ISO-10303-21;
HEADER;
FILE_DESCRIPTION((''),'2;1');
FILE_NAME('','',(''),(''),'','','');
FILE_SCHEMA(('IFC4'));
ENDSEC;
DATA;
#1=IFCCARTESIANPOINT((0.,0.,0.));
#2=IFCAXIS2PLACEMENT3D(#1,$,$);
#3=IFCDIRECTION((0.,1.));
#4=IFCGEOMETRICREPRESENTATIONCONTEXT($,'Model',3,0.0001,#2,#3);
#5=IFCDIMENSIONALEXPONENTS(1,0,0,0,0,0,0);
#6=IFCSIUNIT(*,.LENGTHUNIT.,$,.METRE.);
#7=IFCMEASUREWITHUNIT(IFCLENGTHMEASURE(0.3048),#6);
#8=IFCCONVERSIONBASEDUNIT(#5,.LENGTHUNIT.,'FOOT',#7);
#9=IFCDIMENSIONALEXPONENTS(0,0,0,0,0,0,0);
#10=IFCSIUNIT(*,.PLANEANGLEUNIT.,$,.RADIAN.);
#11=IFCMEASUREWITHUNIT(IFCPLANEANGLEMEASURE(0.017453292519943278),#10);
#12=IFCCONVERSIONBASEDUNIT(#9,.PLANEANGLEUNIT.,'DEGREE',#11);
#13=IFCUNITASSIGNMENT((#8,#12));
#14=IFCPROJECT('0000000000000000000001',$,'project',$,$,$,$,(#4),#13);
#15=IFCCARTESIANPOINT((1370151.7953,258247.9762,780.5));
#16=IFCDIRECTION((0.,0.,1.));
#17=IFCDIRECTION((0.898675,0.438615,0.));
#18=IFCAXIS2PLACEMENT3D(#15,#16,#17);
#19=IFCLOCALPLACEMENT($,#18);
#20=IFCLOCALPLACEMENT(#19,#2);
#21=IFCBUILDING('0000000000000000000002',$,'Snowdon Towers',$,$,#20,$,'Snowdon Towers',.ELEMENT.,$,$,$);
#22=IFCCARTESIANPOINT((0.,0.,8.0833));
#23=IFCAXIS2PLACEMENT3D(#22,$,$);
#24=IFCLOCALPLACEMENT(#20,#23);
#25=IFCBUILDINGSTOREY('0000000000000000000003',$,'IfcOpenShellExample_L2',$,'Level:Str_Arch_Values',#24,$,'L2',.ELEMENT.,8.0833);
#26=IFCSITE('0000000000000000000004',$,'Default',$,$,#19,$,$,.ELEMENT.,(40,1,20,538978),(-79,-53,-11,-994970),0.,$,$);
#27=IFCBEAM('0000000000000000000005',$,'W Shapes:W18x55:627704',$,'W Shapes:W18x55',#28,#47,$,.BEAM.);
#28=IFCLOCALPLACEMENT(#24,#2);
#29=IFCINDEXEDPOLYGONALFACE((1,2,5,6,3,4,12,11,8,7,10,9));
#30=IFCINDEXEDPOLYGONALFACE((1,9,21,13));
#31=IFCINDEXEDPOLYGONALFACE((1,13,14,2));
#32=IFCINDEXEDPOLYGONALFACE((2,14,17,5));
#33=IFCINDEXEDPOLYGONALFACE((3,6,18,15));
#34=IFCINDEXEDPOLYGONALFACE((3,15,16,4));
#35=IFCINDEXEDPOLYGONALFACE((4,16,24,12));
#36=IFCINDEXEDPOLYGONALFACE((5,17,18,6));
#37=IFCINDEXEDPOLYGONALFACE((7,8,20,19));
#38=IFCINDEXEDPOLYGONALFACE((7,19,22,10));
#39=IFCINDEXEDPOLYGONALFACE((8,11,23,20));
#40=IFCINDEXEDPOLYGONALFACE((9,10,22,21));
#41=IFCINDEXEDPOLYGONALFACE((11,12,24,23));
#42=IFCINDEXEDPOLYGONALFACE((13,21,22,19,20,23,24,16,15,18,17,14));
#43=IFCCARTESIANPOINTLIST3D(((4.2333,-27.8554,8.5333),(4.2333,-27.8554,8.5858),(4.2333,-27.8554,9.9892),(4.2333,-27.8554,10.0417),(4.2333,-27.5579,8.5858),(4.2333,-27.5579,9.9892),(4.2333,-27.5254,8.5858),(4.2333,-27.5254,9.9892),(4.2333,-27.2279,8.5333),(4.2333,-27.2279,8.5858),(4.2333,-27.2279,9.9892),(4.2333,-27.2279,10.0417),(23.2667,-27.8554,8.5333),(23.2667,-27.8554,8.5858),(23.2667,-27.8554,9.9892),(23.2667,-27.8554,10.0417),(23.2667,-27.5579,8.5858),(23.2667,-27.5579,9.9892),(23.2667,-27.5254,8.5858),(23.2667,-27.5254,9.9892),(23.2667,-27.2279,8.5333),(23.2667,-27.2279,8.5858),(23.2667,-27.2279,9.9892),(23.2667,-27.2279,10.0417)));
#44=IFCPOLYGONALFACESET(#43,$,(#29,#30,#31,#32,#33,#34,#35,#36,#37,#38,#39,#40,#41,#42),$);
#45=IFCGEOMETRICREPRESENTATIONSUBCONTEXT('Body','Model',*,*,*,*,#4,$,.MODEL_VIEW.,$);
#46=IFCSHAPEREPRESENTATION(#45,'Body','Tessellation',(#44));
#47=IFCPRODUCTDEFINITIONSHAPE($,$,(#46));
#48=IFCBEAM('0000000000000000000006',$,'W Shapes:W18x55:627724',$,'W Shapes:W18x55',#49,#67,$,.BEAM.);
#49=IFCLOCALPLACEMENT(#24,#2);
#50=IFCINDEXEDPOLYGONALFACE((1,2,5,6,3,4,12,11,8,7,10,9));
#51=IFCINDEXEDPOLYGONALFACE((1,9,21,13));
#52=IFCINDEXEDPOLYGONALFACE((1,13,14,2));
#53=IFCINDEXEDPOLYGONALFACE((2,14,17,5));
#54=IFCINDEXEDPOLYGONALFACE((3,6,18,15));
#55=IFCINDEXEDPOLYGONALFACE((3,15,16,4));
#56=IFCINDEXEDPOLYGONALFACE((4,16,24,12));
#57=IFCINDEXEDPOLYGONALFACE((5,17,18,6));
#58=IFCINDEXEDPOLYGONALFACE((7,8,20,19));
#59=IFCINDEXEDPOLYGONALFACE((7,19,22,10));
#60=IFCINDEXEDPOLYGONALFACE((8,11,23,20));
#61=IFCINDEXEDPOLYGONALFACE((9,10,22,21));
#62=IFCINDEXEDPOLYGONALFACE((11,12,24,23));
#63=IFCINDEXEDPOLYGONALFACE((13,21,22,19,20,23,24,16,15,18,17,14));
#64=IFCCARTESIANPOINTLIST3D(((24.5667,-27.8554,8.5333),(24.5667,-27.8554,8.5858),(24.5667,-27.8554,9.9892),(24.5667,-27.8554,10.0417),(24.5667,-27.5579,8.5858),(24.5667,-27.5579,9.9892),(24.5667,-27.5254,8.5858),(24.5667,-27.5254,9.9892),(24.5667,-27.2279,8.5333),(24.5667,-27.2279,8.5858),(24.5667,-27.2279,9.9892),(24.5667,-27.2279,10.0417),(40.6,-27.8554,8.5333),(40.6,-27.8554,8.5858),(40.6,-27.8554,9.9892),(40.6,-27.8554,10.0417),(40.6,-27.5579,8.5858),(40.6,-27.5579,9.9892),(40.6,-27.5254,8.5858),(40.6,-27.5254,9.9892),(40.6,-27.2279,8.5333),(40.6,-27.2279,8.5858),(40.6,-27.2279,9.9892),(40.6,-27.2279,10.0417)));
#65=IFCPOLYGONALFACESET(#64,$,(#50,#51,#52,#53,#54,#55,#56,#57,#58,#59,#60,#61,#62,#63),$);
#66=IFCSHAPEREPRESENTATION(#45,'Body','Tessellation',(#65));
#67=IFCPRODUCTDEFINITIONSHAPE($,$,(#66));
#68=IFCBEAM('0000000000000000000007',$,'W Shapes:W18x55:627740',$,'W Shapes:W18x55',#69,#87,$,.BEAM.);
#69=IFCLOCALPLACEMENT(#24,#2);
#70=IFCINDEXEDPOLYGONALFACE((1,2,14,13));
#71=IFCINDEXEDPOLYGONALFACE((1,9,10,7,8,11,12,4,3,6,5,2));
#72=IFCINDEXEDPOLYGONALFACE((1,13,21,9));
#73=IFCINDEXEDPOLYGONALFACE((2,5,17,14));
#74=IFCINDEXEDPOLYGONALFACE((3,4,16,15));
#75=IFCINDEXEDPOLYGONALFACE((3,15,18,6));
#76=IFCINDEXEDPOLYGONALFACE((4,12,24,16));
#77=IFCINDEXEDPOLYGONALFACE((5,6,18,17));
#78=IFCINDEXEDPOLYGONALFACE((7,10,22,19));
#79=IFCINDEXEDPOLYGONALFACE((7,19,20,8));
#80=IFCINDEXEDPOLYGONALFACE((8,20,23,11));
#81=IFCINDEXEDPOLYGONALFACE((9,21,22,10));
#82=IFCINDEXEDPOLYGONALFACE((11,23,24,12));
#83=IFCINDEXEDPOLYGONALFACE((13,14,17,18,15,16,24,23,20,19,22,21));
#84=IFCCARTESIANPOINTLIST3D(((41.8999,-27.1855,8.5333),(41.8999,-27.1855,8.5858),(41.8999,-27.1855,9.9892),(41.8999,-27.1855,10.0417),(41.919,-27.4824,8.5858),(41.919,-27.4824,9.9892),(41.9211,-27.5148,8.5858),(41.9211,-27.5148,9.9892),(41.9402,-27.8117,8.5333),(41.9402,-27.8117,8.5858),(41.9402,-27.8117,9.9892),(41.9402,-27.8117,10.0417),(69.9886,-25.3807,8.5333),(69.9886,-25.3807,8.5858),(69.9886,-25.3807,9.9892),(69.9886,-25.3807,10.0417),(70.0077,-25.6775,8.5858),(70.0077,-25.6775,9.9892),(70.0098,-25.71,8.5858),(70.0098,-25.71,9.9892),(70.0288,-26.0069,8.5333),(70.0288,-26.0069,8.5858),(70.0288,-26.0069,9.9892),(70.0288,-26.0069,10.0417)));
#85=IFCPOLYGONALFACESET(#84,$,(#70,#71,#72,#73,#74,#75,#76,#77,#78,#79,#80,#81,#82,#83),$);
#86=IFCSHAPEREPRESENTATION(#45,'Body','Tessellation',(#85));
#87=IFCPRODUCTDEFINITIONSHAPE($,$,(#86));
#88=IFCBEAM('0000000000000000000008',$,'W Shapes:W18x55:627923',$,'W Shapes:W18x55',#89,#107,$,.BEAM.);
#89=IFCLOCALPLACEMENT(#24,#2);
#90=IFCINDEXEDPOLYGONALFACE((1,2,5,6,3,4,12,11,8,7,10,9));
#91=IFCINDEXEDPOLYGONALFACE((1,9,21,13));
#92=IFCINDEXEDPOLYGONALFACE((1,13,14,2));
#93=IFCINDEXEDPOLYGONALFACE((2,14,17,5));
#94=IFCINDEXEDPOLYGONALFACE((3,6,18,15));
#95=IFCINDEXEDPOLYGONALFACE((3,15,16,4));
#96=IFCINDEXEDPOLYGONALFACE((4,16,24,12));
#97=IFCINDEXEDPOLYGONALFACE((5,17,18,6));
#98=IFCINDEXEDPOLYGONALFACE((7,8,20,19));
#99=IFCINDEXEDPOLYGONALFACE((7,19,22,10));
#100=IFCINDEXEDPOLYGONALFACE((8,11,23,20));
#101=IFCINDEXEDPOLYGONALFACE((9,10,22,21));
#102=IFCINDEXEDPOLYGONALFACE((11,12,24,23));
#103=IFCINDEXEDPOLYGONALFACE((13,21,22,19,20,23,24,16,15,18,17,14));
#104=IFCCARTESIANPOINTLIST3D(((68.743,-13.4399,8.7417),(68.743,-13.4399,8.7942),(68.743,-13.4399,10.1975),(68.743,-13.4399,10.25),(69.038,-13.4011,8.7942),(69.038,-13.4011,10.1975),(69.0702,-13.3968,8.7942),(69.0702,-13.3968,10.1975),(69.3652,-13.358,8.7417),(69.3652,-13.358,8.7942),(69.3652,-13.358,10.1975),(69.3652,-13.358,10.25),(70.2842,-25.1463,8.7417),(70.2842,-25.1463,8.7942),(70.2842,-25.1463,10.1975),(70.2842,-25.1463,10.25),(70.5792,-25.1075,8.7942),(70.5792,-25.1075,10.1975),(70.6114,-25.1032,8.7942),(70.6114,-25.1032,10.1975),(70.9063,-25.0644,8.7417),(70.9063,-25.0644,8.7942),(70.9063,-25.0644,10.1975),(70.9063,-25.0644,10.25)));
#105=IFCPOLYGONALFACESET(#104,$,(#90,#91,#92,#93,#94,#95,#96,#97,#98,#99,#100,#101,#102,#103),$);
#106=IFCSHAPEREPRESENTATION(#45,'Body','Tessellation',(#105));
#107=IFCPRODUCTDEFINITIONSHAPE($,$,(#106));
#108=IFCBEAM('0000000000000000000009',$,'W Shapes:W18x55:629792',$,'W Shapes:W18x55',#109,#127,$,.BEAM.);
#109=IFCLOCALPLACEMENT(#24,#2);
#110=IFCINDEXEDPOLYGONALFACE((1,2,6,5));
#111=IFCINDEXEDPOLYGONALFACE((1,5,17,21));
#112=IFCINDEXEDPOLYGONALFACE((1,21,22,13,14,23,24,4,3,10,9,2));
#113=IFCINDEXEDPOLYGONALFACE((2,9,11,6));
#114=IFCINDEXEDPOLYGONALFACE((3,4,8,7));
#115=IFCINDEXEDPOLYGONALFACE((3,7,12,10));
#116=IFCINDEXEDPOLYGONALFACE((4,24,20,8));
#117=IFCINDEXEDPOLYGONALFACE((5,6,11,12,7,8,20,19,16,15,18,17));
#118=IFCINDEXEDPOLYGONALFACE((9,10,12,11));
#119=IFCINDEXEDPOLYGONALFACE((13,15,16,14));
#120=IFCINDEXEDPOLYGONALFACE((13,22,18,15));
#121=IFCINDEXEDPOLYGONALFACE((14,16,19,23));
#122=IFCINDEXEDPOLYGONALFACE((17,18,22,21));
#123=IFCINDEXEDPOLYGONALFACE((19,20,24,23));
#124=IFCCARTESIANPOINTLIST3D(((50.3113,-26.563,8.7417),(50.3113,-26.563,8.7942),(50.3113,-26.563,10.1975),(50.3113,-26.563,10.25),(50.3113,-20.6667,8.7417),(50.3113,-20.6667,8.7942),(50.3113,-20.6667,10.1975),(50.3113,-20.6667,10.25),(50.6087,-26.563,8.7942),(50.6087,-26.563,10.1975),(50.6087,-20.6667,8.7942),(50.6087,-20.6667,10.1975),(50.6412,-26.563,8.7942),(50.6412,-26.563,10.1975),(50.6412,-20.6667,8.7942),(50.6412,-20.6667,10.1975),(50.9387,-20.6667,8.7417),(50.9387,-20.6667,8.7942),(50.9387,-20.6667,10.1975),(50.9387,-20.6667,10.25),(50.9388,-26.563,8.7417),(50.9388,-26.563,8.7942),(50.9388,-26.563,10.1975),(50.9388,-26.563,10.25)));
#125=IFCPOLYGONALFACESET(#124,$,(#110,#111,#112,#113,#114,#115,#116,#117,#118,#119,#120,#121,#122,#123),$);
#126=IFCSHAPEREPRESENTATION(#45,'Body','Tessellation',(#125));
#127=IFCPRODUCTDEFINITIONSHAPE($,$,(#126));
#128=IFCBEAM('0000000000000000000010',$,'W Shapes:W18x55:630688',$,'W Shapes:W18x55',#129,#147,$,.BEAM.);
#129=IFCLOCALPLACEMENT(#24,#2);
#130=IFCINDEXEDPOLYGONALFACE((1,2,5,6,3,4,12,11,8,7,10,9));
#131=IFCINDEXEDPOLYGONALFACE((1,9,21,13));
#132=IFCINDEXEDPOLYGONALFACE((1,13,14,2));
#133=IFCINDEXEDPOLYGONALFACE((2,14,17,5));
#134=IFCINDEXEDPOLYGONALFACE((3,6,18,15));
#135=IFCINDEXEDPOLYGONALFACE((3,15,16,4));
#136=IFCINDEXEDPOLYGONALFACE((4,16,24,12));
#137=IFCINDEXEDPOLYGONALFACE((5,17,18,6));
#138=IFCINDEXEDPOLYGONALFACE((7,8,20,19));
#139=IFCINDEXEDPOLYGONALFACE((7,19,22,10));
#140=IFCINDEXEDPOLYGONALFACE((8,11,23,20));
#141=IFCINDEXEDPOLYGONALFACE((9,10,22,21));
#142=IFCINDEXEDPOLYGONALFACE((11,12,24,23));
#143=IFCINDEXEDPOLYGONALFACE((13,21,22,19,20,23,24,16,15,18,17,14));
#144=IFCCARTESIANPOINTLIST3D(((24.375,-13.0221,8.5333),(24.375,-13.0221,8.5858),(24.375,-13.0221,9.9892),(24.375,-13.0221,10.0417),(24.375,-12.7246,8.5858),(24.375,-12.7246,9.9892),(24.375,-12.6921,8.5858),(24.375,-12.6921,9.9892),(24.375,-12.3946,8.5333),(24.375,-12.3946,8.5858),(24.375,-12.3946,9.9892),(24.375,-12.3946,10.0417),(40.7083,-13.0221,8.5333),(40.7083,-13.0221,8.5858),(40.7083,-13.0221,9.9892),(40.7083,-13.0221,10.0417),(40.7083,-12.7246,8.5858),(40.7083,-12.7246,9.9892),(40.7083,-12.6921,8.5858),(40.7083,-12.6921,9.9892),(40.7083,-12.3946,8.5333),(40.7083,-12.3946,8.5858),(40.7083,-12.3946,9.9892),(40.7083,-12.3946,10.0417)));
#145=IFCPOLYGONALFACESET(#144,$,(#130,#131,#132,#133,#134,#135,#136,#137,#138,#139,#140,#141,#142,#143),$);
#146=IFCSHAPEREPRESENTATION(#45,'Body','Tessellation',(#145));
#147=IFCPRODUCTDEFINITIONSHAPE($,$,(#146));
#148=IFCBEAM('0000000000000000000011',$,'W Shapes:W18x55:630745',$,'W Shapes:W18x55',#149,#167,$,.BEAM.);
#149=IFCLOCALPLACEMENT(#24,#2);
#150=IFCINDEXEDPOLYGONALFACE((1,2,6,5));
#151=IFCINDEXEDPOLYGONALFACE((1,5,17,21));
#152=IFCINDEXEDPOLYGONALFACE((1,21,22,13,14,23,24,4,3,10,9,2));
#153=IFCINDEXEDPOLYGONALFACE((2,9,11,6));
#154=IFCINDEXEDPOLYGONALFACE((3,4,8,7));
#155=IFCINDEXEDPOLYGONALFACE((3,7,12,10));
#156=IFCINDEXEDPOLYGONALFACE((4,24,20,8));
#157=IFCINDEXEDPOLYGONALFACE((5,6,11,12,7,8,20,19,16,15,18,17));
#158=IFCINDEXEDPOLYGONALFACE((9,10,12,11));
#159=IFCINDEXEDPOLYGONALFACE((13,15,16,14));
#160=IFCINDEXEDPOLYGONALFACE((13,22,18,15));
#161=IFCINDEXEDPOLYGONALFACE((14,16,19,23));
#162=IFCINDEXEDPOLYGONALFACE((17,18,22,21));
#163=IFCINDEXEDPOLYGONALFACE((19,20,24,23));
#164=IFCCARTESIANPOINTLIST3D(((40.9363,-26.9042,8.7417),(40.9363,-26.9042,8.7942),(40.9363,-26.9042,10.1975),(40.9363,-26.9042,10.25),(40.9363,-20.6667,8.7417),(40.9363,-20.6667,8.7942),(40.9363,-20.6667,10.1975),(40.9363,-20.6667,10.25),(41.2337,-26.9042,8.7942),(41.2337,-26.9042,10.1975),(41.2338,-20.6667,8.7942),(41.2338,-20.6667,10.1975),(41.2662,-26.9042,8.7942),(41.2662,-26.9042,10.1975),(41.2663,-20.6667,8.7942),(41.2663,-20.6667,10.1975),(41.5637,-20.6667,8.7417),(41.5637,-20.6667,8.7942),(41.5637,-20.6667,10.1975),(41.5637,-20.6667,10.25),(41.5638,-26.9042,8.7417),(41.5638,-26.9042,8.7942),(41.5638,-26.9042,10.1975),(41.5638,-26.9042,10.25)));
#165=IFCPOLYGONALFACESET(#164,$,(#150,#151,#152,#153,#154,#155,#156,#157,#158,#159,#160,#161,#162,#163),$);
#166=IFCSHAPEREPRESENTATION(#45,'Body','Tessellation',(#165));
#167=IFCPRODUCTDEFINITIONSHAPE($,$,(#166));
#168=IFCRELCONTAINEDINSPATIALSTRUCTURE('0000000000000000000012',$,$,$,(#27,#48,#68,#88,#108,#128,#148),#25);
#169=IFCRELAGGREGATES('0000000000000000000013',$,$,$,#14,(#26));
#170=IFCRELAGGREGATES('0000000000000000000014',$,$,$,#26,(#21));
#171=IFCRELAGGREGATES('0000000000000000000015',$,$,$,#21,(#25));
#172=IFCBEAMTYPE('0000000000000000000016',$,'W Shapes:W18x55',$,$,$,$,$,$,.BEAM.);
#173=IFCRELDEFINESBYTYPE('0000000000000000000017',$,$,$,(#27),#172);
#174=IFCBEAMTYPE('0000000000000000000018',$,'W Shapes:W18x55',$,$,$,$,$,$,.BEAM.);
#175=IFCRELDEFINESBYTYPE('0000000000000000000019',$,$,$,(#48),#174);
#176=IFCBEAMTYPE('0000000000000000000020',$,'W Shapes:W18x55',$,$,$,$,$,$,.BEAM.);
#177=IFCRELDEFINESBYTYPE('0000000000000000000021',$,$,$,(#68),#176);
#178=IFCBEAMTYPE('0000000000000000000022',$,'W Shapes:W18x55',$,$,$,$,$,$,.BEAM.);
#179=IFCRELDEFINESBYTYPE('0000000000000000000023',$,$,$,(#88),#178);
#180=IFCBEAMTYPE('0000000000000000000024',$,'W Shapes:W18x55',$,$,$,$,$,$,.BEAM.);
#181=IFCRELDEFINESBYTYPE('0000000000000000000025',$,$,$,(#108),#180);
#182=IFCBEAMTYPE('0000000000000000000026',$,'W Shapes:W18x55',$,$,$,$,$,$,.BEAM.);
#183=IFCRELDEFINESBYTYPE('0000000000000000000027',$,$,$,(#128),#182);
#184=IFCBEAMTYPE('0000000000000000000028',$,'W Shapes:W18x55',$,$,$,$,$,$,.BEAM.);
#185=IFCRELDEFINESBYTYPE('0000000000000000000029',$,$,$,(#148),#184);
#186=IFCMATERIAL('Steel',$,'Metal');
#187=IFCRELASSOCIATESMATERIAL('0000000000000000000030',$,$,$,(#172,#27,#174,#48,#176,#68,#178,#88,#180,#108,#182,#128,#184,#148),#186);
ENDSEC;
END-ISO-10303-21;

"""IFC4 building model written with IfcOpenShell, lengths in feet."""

from ifc_helpers import new_model, entity, si_unit, converted_unit, direction, frame, origin, place, context, subcontext, project, spatial, indexed_curve, outline, extrude, source, transform, mapped, material, type_object, type_shapes, element, save


model = new_model("IFC4")

# Units and contexts
model_context = context("Model", 3, precision=0.0001, world=origin(), true_north=direction((0.0, 1.0)))
body_context = subcontext(model_context, "Body", "Model", "MODEL_VIEW")
ifc_project = project(units=[converted_unit("LENGTHUNIT", "FOOT", entity("IfcLengthMeasure", 0.3048), si_unit("LENGTHUNIT", "METRE"), dimensions=[1, 0, 0, 0, 0, 0, 0]), converted_unit("PLANEANGLEUNIT", "DEGREE", entity("IfcPlaneAngleMeasure", 0.017453292519943278), si_unit("PLANEANGLEUNIT", "RADIAN"), dimensions=[0, 0, 0, 0, 0, 0, 0])], contexts=[model_context])

# Site, building, storey
site_placement = place(None, frame((1370151.7953, 258247.9762, 780.5), z_axis=(0.0, 0.0, 1.0), x_axis=(0.898675, 0.438615, 0.0)))
site = spatial("IfcSite", under=ifc_project, at=site_placement, Name="Default", CompositionType="ELEMENT", RefLatitude=(40, 1, 20, 538978), RefLongitude=(-79, -53, -11, -994970), RefElevation=0.0)
building_placement = place(site_placement, origin())
building = spatial("IfcBuilding", under=site, at=building_placement, Name="Snowdon Towers", LongName="Snowdon Towers", CompositionType="ELEMENT")
storey_placement = place(building_placement, frame((0.0, 0.0, 8.0833)))
storey = spatial("IfcBuildingStorey", under=building, at=storey_placement, Name="IfcOpenShellExample_L2", ObjectType="Level:Str_Arch_Values", LongName="L2", CompositionType="ELEMENT", Elevation=8.0833)

# Beams
ifc_material = material(Name="Steel", Category="Metal")
beam_type_1 = type_object("IfcBeamType", Name="W Shapes:W18x55", PredefinedType="BEAM", material=ifc_material)
shared_shape_1 = source(origin(), body_context, "Body", "SweptSolid", [
    extrude(outline(indexed_curve([(-0.3138, -0.7017), (-0.3138, -0.7542), (0.3138, -0.7542), (0.3138, -0.7017), (0.0162, -0.7017), (0.0162, 0.7017), (0.3138, 0.7017), (0.3138, 0.7542), (-0.3137, 0.7542), (-0.3137, 0.7017), (-0.0163, 0.7017), (-0.0163, -0.7017), (-0.3138, -0.7017)], self_intersect=False)), frame((-9.6, 0.0, 0.0), z_axis=(-1.0, 0.0, 0.0), x_axis=(0.0, -1.0, 0.0)), (0.0, 0.0, -1.0), 19.0333),
])
type_shapes(beam_type_1, [shared_shape_1])
beam_1_placement = place(storey_placement, frame((13.8333, -27.5417, 9.2875)))
element("IfcBeam", 1, at=beam_1_placement, inside=storey, type_object=beam_type_1, material=ifc_material, Name="W Shapes:W18x55:627704", ObjectType="W Shapes:W18x55", PredefinedType="BEAM", context=body_context, shape_type="MappedRepresentation", body=[
    mapped(shared_shape_1, transform((0.0, 0.0, 0.0), scale=1.0)),
])
beam_type_2 = type_object("IfcBeamType", Name="W Shapes:W18x55", PredefinedType="BEAM", material=ifc_material)
shared_shape_2 = source(origin(), body_context, "Body", "SweptSolid", [
    extrude(outline(indexed_curve([(-0.3138, -0.7017), (-0.3138, -0.7542), (0.3138, -0.7542), (0.3138, -0.7017), (0.0162, -0.7017), (0.0162, 0.7017), (0.3138, 0.7017), (0.3138, 0.7542), (-0.3137, 0.7542), (-0.3137, 0.7017), (-0.0163, 0.7017), (-0.0163, -0.7017), (-0.3138, -0.7017)], self_intersect=False)), frame((-8.0167, 0.0, 0.0), z_axis=(-1.0, 0.0, 0.0), x_axis=(0.0, -1.0, 0.0)), (0.0, 0.0, -1.0), 16.0333),
])
type_shapes(beam_type_2, [shared_shape_2])
beam_2_placement = place(storey_placement, frame((32.5833, -27.5417, 9.2875)))
element("IfcBeam", 2, at=beam_2_placement, inside=storey, type_object=beam_type_2, material=ifc_material, Name="W Shapes:W18x55:627724", ObjectType="W Shapes:W18x55", PredefinedType="BEAM", context=body_context, shape_type="MappedRepresentation", body=[
    mapped(shared_shape_2, transform((0.0, 0.0, 0.0), scale=1.0)),
])
beam_type_3 = type_object("IfcBeamType", Name="W Shapes:W18x55", PredefinedType="BEAM", material=ifc_material)
shared_shape_3 = source(origin(), body_context, "Body", "SweptSolid", [
    extrude(outline(indexed_curve([(-0.3138, -0.7017), (-0.3138, -0.7542), (0.3138, -0.7542), (0.3138, -0.7017), (0.0162, -0.7017), (0.0162, 0.7017), (0.3138, 0.7017), (0.3138, 0.7542), (-0.3137, 0.7542), (-0.3137, 0.7017), (-0.0163, 0.7017), (-0.0163, -0.7017), (-0.3138, -0.7017)], self_intersect=False)), frame((-14.3614, 0.0, 0.0), z_axis=(-1.0, 0.0, 0.0), x_axis=(0.0, -1.0, 0.0)), (0.0, 0.0, -1.0), 28.1466),
])
type_shapes(beam_type_3, [shared_shape_3])
beam_3_placement = place(storey_placement, frame((56.2518, -26.5777, 9.2875), z_axis=(0.0, 0.0, 1.0), x_axis=(0.997942, 0.064123, 0.0)))
element("IfcBeam", 3, at=beam_3_placement, inside=storey, type_object=beam_type_3, material=ifc_material, Name="W Shapes:W18x55:627740", ObjectType="W Shapes:W18x55", PredefinedType="BEAM", context=body_context, shape_type="MappedRepresentation", body=[
    mapped(shared_shape_3, transform((0.0, 0.0, 0.0), scale=1.0)),
])
beam_type_4 = type_object("IfcBeamType", Name="W Shapes:W18x55", PredefinedType="BEAM", material=ifc_material)
shared_shape_4 = source(origin(), body_context, "Body", "SweptSolid", [
    extrude(outline(indexed_curve([(-0.3138, -0.7017), (-0.3138, -0.7542), (0.3138, -0.7542), (0.3138, -0.7017), (0.0162, -0.7017), (0.0162, 0.7017), (0.3138, 0.7017), (0.3138, 0.7542), (-0.3137, 0.7542), (-0.3137, 0.7017), (-0.0163, 0.7017), (-0.0163, -0.7017), (-0.3138, -0.7017)], self_intersect=False)), frame((-5.9188, 0.0, 0.0), z_axis=(-1.0, 0.0, 0.0), x_axis=(0.0, -1.0, 0.0)), (0.0, 0.0, -1.0), 11.8075),
])
type_shapes(beam_type_4, [shared_shape_4])
beam_4_placement = place(storey_placement, frame((69.8266, -19.2671, 9.4958), z_axis=(0.0, 0.0, 1.0), x_axis=(0.130526, -0.991445, 0.0)))
element("IfcBeam", 4, at=beam_4_placement, inside=storey, type_object=beam_type_4, material=ifc_material, Name="W Shapes:W18x55:627923", ObjectType="W Shapes:W18x55", PredefinedType="BEAM", context=body_context, shape_type="MappedRepresentation", body=[
    mapped(shared_shape_4, transform((0.0, 0.0, 0.0), scale=1.0)),
])
beam_type_5 = type_object("IfcBeamType", Name="W Shapes:W18x55", PredefinedType="BEAM", material=ifc_material)
shared_shape_5 = source(origin(), body_context, "Body", "SweptSolid", [
    extrude(outline(indexed_curve([(-0.3138, -0.7017), (-0.3138, -0.7542), (0.3138, -0.7542), (0.3138, -0.7017), (0.0162, -0.7017), (0.0162, 0.7017), (0.3138, 0.7017), (0.3138, 0.7542), (-0.3137, 0.7542), (-0.3137, 0.7017), (-0.0163, 0.7017), (-0.0163, -0.7017), (-0.3138, -0.7017)], self_intersect=False)), frame((-2.8655, 0.0, 0.0), z_axis=(-1.0, 0.0, 0.0), x_axis=(0.0, -1.0, 0.0)), (0.0, 0.0, -1.0), 5.8964),
])
type_shapes(beam_type_5, [shared_shape_5])
beam_5_placement = place(storey_placement, frame((50.625, -23.5321, 9.4958), z_axis=(0.0, 0.0, 1.0), x_axis=(0.0, -1.0, 0.0)))
element("IfcBeam", 5, at=beam_5_placement, inside=storey, type_object=beam_type_5, material=ifc_material, Name="W Shapes:W18x55:629792", ObjectType="W Shapes:W18x55", PredefinedType="BEAM", context=body_context, shape_type="MappedRepresentation", body=[
    mapped(shared_shape_5, transform((0.0, 0.0, 0.0), scale=1.0)),
])
beam_type_6 = type_object("IfcBeamType", Name="W Shapes:W18x55", PredefinedType="BEAM", material=ifc_material)
shared_shape_6 = source(origin(), body_context, "Body", "SweptSolid", [
    extrude(outline(indexed_curve([(-0.3138, -0.7017), (-0.3138, -0.7542), (0.3138, -0.7542), (0.3138, -0.7017), (0.0162, -0.7017), (0.0162, 0.7017), (0.3138, 0.7017), (0.3138, 0.7542), (-0.3137, 0.7542), (-0.3137, 0.7017), (-0.0163, 0.7017), (-0.0163, -0.7017), (-0.3138, -0.7017)], self_intersect=False)), frame((-8.2083, 0.0, 0.0), z_axis=(-1.0, 0.0, 0.0), x_axis=(0.0, -1.0, 0.0)), (0.0, 0.0, -1.0), 16.3333),
])
type_shapes(beam_type_6, [shared_shape_6])
beam_6_placement = place(storey_placement, frame((32.5833, -12.7083, 9.2875)))
element("IfcBeam", 6, at=beam_6_placement, inside=storey, type_object=beam_type_6, material=ifc_material, Name="W Shapes:W18x55:630688", ObjectType="W Shapes:W18x55", PredefinedType="BEAM", context=body_context, shape_type="MappedRepresentation", body=[
    mapped(shared_shape_6, transform((0.0, 0.0, 0.0), scale=1.0)),
])
beam_type_7 = type_object("IfcBeamType", Name="W Shapes:W18x55", PredefinedType="BEAM", material=ifc_material)
shared_shape_7 = source(origin(), body_context, "Body", "SweptSolid", [
    extrude(outline(indexed_curve([(-0.3138, -0.7017), (-0.3138, -0.7542), (0.3138, -0.7542), (0.3138, -0.7017), (0.0162, -0.7017), (0.0162, 0.7017), (0.3138, 0.7017), (0.3138, 0.7542), (-0.3137, 0.7542), (-0.3137, 0.7017), (-0.0163, 0.7017), (-0.0163, -0.7017), (-0.3138, -0.7017)], self_intersect=False)), frame((-3.3958, 0.0, 0.0), z_axis=(-1.0, 0.0, 0.0), x_axis=(0.0, -1.0, 0.0)), (0.0, 0.0, -1.0), 6.2375),
])
type_shapes(beam_type_7, [shared_shape_7])
beam_7_placement = place(storey_placement, frame((41.25, -24.0625, 9.4958), z_axis=(0.0, 0.0, 1.0), x_axis=(0.0, -1.0, 0.0)))
element("IfcBeam", 7, at=beam_7_placement, inside=storey, type_object=beam_type_7, material=ifc_material, Name="W Shapes:W18x55:630745", ObjectType="W Shapes:W18x55", PredefinedType="BEAM", context=body_context, shape_type="MappedRepresentation", body=[
    mapped(shared_shape_7, transform((0.0, 0.0, 0.0), scale=1.0)),
])

save(model, "model.ifc")
